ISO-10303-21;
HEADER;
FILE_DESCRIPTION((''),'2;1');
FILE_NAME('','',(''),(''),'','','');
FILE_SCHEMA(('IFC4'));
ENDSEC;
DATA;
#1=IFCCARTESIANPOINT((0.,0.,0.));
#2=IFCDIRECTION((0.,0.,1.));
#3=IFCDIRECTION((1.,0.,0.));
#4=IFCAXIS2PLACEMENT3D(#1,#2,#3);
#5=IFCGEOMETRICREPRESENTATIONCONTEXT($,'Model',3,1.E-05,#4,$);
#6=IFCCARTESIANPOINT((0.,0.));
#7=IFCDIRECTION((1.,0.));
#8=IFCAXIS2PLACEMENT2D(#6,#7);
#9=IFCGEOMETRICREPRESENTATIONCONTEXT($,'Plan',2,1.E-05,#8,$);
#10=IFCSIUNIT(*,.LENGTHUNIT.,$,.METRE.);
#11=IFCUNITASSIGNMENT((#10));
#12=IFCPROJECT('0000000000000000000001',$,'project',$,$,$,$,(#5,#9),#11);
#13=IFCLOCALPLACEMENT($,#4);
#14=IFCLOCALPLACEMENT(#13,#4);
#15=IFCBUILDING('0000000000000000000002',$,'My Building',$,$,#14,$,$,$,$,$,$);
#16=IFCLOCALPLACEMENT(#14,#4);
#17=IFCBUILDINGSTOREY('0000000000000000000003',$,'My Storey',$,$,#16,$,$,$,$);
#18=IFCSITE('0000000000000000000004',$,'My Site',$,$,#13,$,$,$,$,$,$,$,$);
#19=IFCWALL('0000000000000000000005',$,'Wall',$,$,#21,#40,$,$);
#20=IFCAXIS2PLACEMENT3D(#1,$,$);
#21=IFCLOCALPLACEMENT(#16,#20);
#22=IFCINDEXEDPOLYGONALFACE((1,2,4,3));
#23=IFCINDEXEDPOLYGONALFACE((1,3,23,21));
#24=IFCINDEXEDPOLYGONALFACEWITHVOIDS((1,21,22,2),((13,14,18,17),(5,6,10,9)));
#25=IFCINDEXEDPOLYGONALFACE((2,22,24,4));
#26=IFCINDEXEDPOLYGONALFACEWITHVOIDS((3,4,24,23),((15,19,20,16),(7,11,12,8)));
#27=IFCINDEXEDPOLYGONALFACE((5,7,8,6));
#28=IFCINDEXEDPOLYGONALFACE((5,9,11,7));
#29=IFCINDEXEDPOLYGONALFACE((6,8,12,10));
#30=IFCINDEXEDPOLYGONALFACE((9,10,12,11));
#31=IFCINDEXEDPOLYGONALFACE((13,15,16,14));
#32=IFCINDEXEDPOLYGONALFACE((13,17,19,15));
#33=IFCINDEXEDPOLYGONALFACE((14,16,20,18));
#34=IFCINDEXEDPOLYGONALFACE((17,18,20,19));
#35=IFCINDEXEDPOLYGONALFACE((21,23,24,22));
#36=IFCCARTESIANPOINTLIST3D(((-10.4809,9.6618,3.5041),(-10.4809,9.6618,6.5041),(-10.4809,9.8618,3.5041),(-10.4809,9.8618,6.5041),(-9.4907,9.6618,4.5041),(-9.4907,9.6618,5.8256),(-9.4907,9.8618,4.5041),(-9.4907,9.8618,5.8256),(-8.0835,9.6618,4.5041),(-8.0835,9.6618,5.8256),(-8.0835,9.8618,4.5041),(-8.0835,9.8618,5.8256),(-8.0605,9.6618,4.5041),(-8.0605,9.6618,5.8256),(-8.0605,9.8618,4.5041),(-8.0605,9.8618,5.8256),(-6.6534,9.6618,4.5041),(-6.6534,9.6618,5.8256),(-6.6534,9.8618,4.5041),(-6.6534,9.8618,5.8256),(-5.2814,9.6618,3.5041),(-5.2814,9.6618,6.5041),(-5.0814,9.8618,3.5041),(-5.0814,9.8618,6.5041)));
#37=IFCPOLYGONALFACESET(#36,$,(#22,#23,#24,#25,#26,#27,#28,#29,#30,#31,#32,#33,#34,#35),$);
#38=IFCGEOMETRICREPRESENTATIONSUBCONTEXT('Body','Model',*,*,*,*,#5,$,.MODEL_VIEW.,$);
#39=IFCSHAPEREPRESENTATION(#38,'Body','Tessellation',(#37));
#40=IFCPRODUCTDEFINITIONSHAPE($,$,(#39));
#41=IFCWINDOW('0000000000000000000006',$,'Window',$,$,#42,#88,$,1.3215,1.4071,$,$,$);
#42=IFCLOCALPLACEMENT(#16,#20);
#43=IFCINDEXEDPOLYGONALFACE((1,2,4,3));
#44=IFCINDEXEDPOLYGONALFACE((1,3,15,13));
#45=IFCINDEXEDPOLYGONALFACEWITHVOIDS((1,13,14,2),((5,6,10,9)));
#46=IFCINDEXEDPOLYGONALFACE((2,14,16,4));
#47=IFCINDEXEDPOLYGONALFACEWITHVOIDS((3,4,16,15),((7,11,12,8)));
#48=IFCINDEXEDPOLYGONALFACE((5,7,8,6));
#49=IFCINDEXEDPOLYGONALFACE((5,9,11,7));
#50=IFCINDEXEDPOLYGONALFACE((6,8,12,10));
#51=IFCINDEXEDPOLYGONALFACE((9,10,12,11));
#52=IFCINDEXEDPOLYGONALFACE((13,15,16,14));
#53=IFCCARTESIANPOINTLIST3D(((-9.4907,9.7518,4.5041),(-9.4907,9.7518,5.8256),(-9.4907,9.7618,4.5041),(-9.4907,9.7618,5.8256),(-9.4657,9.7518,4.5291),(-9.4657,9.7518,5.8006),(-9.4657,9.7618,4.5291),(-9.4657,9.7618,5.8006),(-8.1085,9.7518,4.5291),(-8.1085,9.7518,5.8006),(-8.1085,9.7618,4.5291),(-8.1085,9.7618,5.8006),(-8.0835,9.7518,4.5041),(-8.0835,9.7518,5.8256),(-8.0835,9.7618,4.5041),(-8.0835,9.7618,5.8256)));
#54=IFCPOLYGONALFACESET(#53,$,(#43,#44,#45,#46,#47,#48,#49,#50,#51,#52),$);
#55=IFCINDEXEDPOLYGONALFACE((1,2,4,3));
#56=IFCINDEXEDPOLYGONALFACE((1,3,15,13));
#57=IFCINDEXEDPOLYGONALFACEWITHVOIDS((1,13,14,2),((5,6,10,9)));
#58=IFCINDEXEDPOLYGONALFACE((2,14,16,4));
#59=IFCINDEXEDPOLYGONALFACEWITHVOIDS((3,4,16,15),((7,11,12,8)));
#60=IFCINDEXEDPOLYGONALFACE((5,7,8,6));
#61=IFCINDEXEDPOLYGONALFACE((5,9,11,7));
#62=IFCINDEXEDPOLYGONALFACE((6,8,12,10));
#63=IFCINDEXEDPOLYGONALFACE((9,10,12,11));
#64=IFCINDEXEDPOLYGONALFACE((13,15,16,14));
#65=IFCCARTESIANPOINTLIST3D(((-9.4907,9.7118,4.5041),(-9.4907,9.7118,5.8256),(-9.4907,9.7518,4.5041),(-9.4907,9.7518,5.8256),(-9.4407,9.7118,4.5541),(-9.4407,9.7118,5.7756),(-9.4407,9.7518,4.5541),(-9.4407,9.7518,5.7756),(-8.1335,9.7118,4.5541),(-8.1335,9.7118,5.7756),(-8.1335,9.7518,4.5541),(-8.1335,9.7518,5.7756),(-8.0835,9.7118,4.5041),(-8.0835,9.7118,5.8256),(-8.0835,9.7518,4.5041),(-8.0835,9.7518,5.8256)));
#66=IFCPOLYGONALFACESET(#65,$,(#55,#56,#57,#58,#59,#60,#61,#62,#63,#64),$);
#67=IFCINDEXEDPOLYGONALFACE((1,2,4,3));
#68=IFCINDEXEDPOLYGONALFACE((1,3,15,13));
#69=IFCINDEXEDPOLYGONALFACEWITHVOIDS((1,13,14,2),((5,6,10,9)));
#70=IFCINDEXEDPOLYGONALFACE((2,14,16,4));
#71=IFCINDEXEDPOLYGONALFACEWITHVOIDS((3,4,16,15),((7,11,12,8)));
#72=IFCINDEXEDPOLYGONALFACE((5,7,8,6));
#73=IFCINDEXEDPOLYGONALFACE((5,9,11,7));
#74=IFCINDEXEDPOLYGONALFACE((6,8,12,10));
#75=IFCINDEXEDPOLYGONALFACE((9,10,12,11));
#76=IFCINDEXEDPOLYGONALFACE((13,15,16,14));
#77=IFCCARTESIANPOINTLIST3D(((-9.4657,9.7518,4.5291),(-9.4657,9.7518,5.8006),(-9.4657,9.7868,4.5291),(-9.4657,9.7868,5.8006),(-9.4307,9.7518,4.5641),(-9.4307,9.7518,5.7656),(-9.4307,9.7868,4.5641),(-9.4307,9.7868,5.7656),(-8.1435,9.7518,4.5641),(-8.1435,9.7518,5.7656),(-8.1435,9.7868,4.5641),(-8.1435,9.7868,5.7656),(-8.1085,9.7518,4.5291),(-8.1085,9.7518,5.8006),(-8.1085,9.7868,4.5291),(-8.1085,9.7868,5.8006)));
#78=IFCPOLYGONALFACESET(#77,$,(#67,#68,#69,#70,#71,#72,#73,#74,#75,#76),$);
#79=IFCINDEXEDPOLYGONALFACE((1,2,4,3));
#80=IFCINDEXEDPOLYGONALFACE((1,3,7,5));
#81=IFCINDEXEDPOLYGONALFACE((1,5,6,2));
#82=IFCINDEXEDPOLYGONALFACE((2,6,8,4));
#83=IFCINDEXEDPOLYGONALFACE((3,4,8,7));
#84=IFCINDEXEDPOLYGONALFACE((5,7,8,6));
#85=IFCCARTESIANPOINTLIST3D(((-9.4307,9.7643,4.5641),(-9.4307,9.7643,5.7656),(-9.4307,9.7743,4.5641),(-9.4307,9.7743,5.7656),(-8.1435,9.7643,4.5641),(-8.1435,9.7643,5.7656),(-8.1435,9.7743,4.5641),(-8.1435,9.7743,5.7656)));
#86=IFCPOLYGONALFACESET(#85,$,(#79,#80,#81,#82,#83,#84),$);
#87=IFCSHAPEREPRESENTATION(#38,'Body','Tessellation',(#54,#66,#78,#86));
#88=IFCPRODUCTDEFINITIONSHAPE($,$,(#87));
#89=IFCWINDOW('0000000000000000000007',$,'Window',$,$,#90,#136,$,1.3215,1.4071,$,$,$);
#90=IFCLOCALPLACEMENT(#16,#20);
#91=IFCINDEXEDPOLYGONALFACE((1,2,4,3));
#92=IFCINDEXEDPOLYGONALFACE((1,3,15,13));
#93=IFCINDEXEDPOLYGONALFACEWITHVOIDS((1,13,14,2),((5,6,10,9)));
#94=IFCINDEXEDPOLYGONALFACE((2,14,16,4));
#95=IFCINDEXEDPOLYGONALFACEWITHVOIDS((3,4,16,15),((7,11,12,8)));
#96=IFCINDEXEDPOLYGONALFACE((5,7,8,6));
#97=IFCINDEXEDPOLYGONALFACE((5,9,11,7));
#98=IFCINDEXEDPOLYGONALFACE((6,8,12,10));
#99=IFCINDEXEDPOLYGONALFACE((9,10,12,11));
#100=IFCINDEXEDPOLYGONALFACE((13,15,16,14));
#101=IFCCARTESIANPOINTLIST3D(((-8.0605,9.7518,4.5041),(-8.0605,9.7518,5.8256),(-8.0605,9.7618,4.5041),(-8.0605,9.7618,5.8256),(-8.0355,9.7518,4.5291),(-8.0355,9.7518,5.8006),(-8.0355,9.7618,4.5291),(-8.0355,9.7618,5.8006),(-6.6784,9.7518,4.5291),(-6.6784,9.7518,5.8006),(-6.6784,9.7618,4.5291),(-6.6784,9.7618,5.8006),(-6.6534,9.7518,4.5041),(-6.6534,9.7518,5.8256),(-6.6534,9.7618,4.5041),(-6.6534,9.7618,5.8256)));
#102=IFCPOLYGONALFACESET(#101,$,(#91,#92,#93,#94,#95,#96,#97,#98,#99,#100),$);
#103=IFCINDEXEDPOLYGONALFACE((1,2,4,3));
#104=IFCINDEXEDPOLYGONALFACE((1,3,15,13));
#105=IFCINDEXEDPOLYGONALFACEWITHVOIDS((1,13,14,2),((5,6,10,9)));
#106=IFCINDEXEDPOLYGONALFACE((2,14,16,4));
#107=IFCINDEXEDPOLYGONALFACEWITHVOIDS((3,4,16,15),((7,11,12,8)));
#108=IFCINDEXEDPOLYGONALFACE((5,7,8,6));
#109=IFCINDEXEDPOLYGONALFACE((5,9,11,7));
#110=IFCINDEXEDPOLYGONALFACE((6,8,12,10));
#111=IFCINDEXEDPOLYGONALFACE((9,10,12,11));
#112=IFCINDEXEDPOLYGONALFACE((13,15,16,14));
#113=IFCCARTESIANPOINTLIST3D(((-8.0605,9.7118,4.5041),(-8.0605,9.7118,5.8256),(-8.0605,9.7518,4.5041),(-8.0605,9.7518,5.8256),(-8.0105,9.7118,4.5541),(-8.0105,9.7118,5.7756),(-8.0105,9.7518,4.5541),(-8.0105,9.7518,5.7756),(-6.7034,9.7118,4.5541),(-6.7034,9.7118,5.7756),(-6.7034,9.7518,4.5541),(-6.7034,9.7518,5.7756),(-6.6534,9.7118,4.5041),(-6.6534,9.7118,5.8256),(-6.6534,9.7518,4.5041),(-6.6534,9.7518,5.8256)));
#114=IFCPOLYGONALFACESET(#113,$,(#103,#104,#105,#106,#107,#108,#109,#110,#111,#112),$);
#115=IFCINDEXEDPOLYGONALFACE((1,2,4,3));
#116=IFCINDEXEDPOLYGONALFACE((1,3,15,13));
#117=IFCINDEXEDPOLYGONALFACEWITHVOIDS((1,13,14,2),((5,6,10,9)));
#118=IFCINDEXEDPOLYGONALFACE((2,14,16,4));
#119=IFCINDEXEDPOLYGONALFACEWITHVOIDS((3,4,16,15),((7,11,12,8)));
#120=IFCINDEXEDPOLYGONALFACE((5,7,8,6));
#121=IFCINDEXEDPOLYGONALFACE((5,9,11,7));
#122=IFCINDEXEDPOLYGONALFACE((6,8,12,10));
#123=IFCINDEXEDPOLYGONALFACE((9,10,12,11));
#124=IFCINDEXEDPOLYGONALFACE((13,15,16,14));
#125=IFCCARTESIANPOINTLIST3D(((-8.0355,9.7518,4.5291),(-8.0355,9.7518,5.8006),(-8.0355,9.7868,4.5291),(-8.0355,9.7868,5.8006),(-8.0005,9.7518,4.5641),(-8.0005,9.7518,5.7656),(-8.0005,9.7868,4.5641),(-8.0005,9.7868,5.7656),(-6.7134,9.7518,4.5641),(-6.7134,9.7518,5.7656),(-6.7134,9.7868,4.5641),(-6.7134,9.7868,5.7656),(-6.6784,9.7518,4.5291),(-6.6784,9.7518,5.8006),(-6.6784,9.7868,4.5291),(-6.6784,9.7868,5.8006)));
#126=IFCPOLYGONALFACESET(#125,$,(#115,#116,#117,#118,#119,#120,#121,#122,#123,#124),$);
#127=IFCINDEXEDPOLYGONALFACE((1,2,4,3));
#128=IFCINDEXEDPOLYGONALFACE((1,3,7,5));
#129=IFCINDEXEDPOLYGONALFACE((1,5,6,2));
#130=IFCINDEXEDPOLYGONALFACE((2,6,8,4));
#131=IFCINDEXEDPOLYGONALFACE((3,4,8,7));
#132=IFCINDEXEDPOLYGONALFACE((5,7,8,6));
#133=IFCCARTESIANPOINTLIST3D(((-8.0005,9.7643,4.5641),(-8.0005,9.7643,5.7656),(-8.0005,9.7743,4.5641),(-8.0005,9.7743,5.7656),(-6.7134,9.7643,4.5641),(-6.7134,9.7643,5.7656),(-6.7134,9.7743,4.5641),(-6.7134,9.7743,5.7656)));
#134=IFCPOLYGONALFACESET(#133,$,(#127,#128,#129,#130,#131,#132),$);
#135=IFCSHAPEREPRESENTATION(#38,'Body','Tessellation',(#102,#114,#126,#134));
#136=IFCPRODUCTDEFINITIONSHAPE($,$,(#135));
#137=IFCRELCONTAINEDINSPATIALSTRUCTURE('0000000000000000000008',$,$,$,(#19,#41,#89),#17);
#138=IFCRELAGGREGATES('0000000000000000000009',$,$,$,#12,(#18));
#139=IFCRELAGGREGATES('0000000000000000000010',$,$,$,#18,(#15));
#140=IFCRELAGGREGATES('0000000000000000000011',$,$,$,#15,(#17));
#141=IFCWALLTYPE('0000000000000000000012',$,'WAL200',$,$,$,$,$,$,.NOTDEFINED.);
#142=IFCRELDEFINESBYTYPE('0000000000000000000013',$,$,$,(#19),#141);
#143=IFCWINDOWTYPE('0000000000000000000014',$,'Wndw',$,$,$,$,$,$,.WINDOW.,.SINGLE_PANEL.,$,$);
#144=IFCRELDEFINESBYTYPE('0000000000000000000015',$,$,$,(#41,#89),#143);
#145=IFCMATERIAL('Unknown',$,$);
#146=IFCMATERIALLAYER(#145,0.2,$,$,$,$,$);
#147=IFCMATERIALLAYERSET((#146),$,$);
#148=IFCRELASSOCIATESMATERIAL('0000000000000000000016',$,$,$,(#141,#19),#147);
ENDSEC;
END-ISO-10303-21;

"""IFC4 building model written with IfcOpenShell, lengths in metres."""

from ifc_helpers import new_model, entity, si_unit, frame, origin_with_axes, origin_2d_with_axis, place, context, subcontext, project, spatial, line, indexed_curve, outline, extrude, shape, source, transform, mapped, material, layer, layer_set, layer_usage, type_object, type_shapes, element, fill, save


model = new_model("IFC4")

# Units and contexts
model_context = context("Model", 3, precision=1e-05, world=origin_with_axes())
plan_context = context("Plan", 2, precision=1e-05, world=origin_2d_with_axis())
body_context_1 = subcontext(model_context, "Body", "Model", "MODEL_VIEW")
body_context_2 = subcontext(plan_context, "Body", "Plan", "PLAN_VIEW")
ifc_project = project(units=[si_unit("LENGTHUNIT", "METRE")], contexts=[model_context, plan_context])

# Site, building, storey
site_placement = place(None, origin_with_axes())
site = spatial("IfcSite", under=ifc_project, at=site_placement, Name="My Site")
building_placement = place(site_placement, origin_with_axes())
building = spatial("IfcBuilding", under=site, at=building_placement, Name="My Building")
storey_placement = place(building_placement, origin_with_axes())
storey = spatial("IfcBuildingStorey", under=building, at=storey_placement, Name="My Storey")

# Shared definitions
ifc_material = material(Name="Unknown")

# Shared definitions
ifc_layer_1 = layer(ifc_material, 0.2)
ifc_layer_set_1 = layer_set([ifc_layer_1])
wall_type_1 = type_object("IfcWallType", Name="WAL200", PredefinedType="NOTDEFINED", material=ifc_layer_set_1)

# Shared definitions
shared_shape_1 = source(origin_with_axes(), body_context_1, "Body", "SweptSolid", [
    extrude(outline(indexed_curve([(0.0, 0.0), (1.4071, 0.0), (1.4071, 1.3215), (0.0, 1.3215)], segments=[line(1, 2, 3, 4, 1)])), frame((0.0, -0.6, 0.0), z_axis=(0.0, -1.0, 0.0), x_axis=(1.0, 0.0, 0.0)), (0.0, 0.0, -1.0), 1.2),
])
window_type_1 = type_object("IfcWindowType", Name="Wndw", PartitioningType="SINGLE_PANEL", PredefinedType="WINDOW")
shared_shape_2 = source(origin_with_axes(), body_context_1, "Body", "SweptSolid", [
    extrude(outline(indexed_curve([(0.0, 0.0), (1.4071, 0.0), (1.4071, 1.3215), (0.0, 1.3215)], segments=[line(1, 2, 3, 4, 1)]), holes=[indexed_curve([(0.025, 0.025), (1.3821, 0.025), (1.3821, 1.2965), (0.025, 1.2965)], segments=[line(1, 2, 3, 4, 1)])]), frame((0.0, 0.09, 0.0), z_axis=(0.0, -1.0, 0.0), x_axis=(1.0, 0.0, 0.0)), (0.0, 0.0, -1.0), 0.01),
    extrude(outline(indexed_curve([(0.0, 0.0), (1.4071, 0.0), (1.4071, 1.3215), (0.0, 1.3215)], segments=[line(1, 2, 3, 4, 1)]), holes=[indexed_curve([(0.05, 0.05), (1.3571, 0.05), (1.3571, 1.2715), (0.05, 1.2715)], segments=[line(1, 2, 3, 4, 1)])]), frame((0.0, 0.05, 0.0), z_axis=(0.0, -1.0, 0.0), x_axis=(1.0, 0.0, 0.0)), (0.0, 0.0, -1.0), 0.04),
    extrude(outline(indexed_curve([(0.0, 0.0), (1.3571, 0.0), (1.3571, 1.2715), (0.0, 1.2715)], segments=[line(1, 2, 3, 4, 1)]), holes=[indexed_curve([(0.035, 0.035), (1.3221, 0.035), (1.3221, 1.2365), (0.035, 1.2365)], segments=[line(1, 2, 3, 4, 1)])]), frame((0.025, 0.09, 0.025), z_axis=(0.0, -1.0, 0.0), x_axis=(1.0, 0.0, 0.0)), (0.0, 0.0, -1.0), 0.035),
    extrude(outline(indexed_curve([(0.035, 0.035), (1.3221, 0.035), (1.3221, 1.2365), (0.035, 1.2365)], segments=[line(1, 2, 3, 4, 1)])), frame((0.025, 0.1025, 0.025), z_axis=(0.0, -1.0, 0.0), x_axis=(1.0, 0.0, 0.0)), (0.0, 0.0, -1.0), 0.01),
])
shared_shape_3 = source(origin_with_axes(), body_context_2, "Body", "Curve2D", [
    entity("IfcIndexedPolyCurve", entity("IfcCartesianPointList2D", [[0.05, 0.05], [1.3571, 0.05]])),
    entity("IfcIndexedPolyCurve", entity("IfcCartesianPointList2D", [[0.0, 0.1], [0.025, 0.1], [0.025, 0.09], [0.05, 0.09], [0.05, 0.05], [0.0, 0.05]]), [entity("IfcLineIndex", [1, 2, 3, 4, 5, 6, 1])]),
    entity("IfcIndexedPolyCurve", entity("IfcCartesianPointList2D", [[1.4071, 0.1], [1.3821, 0.1], [1.3821, 0.09], [1.3571, 0.09], [1.3571, 0.05], [1.4071, 0.05]]), [entity("IfcLineIndex", [1, 2, 3, 4, 5, 6, 1])]),
    entity("IfcIndexedPolyCurve", entity("IfcCartesianPointList2D", [[0.025, 0.09], [0.06, 0.09], [0.06, 0.125], [0.025, 0.125]]), [entity("IfcLineIndex", [1, 2, 3, 4, 1])]),
    entity("IfcIndexedPolyCurve", entity("IfcCartesianPointList2D", [[1.3821, 0.09], [1.3471, 0.09], [1.3471, 0.125], [1.3821, 0.125]]), [entity("IfcLineIndex", [1, 2, 3, 4, 1])]),
    entity("IfcIndexedPolyCurve", entity("IfcCartesianPointList2D", [[0.06, 0.09], [1.3471, 0.09]])),
    entity("IfcIndexedPolyCurve", entity("IfcCartesianPointList2D", [[0.06, 0.125], [1.3471, 0.125]])),
    entity("IfcIndexedPolyCurve", entity("IfcCartesianPointList2D", [[0.06, 0.1075], [1.3471, 0.1075]])),
])
type_shapes(window_type_1, [shared_shape_2, shared_shape_3])

# Wall, openings, windows
ifc_layer_usage_1 = layer_usage(ifc_layer_set_1, "AXIS2", "POSITIVE", 0.0)
wall_1_placement = place(storey_placement, frame((-5.0814, 9.8618, 3.5041), z_axis=(0.0, 0.0, 1.0), x_axis=(-1.0, 0.0, 0.0)))
wall_1 = element("IfcWall", 1, at=wall_1_placement, inside=storey, type_object=wall_type_1, material=ifc_layer_usage_1, Name="Wall", context=body_context_1, shape_type="SweptSolid", body=[
    extrude(outline(indexed_curve([(0.0, 0.0), (0.2, 0.2), (5.3995, 0.2), (5.3995, 0.0)], segments=[line(1, 2, 3, 4, 1)])), origin_with_axes(), (0.0, 0.0, 1.0), 3.0),
])
opening_1_placement = place(wall_1_placement, frame((4.4093, 0.2, 1.0), z_axis=(0.0, 0.0, 1.0), x_axis=(-1.0, 0.0, 0.0)))
opening_1 = element("IfcOpeningElement", 2, at=opening_1_placement, cuts=wall_1, PredefinedType="OPENING", context=body_context_1, shape_type="MappedRepresentation", body=[
    mapped(shared_shape_1, transform((0.0, 0.0, 0.0), x_axis=(1.0, 0.0, 0.0), y_axis=(0.0, 1.0, 0.0), z_axis=(0.0, 0.0, 1.0), scale=1.0)),
])
opening_2_placement = place(wall_1_placement, frame((2.9791, 0.2, 1.0), z_axis=(0.0, 0.0, 1.0), x_axis=(-1.0, 0.0, 0.0)))
opening_2 = element("IfcOpeningElement", 3, at=opening_2_placement, cuts=wall_1, PredefinedType="OPENING", context=body_context_1, shape_type="MappedRepresentation", body=[
    mapped(shared_shape_1, transform((0.0, 0.0, 0.0), x_axis=(1.0, 0.0, 0.0), y_axis=(0.0, 1.0, 0.0), z_axis=(0.0, 0.0, 1.0), scale=1.0)),
])
window_1_placement = place(opening_1_placement, frame((0.0, 0.0, 0.0), z_axis=(0.0, 0.0, 1.0), x_axis=(1.0, 0.0, 0.0)))
window_1 = element("IfcWindow", 4, at=window_1_placement, inside=storey, type_object=window_type_1, Name="Window", OverallHeight=1.3215, OverallWidth=1.4071, shapes=[
    shape(body_context_1, "Body", "MappedRepresentation", [mapped(shared_shape_2, transform((0.0, 0.0, 0.0), x_axis=(1.0, 0.0, 0.0), y_axis=(0.0, 1.0, 0.0), z_axis=(0.0, 0.0, 1.0), scale=1.0))]),
    shape(body_context_2, "Body", "MappedRepresentation", [mapped(shared_shape_3, transform((0.0, 0.0, 0.0), x_axis=(1.0, 0.0, 0.0), y_axis=(0.0, 1.0, 0.0), z_axis=(0.0, 0.0, 1.0), scale=1.0))]),
])
fill(opening_1, window_1)
window_2_placement = place(opening_2_placement, frame((0.0, 0.0, 0.0), z_axis=(0.0, 0.0, 1.0), x_axis=(1.0, 0.0, 0.0)))
window_2 = element("IfcWindow", 5, at=window_2_placement, inside=storey, type_object=window_type_1, Name="Window", OverallHeight=1.3215, OverallWidth=1.4071, shapes=[
    shape(body_context_1, "Body", "MappedRepresentation", [mapped(shared_shape_2, transform((0.0, 0.0, 0.0), x_axis=(1.0, 0.0, 0.0), y_axis=(0.0, 1.0, 0.0), z_axis=(0.0, 0.0, 1.0), scale=1.0))]),
    shape(body_context_2, "Body", "MappedRepresentation", [mapped(shared_shape_3, transform((0.0, 0.0, 0.0), x_axis=(1.0, 0.0, 0.0), y_axis=(0.0, 1.0, 0.0), z_axis=(0.0, 0.0, 1.0), scale=1.0))]),
])
fill(opening_2, window_2)

save(model, "model.ifc")
